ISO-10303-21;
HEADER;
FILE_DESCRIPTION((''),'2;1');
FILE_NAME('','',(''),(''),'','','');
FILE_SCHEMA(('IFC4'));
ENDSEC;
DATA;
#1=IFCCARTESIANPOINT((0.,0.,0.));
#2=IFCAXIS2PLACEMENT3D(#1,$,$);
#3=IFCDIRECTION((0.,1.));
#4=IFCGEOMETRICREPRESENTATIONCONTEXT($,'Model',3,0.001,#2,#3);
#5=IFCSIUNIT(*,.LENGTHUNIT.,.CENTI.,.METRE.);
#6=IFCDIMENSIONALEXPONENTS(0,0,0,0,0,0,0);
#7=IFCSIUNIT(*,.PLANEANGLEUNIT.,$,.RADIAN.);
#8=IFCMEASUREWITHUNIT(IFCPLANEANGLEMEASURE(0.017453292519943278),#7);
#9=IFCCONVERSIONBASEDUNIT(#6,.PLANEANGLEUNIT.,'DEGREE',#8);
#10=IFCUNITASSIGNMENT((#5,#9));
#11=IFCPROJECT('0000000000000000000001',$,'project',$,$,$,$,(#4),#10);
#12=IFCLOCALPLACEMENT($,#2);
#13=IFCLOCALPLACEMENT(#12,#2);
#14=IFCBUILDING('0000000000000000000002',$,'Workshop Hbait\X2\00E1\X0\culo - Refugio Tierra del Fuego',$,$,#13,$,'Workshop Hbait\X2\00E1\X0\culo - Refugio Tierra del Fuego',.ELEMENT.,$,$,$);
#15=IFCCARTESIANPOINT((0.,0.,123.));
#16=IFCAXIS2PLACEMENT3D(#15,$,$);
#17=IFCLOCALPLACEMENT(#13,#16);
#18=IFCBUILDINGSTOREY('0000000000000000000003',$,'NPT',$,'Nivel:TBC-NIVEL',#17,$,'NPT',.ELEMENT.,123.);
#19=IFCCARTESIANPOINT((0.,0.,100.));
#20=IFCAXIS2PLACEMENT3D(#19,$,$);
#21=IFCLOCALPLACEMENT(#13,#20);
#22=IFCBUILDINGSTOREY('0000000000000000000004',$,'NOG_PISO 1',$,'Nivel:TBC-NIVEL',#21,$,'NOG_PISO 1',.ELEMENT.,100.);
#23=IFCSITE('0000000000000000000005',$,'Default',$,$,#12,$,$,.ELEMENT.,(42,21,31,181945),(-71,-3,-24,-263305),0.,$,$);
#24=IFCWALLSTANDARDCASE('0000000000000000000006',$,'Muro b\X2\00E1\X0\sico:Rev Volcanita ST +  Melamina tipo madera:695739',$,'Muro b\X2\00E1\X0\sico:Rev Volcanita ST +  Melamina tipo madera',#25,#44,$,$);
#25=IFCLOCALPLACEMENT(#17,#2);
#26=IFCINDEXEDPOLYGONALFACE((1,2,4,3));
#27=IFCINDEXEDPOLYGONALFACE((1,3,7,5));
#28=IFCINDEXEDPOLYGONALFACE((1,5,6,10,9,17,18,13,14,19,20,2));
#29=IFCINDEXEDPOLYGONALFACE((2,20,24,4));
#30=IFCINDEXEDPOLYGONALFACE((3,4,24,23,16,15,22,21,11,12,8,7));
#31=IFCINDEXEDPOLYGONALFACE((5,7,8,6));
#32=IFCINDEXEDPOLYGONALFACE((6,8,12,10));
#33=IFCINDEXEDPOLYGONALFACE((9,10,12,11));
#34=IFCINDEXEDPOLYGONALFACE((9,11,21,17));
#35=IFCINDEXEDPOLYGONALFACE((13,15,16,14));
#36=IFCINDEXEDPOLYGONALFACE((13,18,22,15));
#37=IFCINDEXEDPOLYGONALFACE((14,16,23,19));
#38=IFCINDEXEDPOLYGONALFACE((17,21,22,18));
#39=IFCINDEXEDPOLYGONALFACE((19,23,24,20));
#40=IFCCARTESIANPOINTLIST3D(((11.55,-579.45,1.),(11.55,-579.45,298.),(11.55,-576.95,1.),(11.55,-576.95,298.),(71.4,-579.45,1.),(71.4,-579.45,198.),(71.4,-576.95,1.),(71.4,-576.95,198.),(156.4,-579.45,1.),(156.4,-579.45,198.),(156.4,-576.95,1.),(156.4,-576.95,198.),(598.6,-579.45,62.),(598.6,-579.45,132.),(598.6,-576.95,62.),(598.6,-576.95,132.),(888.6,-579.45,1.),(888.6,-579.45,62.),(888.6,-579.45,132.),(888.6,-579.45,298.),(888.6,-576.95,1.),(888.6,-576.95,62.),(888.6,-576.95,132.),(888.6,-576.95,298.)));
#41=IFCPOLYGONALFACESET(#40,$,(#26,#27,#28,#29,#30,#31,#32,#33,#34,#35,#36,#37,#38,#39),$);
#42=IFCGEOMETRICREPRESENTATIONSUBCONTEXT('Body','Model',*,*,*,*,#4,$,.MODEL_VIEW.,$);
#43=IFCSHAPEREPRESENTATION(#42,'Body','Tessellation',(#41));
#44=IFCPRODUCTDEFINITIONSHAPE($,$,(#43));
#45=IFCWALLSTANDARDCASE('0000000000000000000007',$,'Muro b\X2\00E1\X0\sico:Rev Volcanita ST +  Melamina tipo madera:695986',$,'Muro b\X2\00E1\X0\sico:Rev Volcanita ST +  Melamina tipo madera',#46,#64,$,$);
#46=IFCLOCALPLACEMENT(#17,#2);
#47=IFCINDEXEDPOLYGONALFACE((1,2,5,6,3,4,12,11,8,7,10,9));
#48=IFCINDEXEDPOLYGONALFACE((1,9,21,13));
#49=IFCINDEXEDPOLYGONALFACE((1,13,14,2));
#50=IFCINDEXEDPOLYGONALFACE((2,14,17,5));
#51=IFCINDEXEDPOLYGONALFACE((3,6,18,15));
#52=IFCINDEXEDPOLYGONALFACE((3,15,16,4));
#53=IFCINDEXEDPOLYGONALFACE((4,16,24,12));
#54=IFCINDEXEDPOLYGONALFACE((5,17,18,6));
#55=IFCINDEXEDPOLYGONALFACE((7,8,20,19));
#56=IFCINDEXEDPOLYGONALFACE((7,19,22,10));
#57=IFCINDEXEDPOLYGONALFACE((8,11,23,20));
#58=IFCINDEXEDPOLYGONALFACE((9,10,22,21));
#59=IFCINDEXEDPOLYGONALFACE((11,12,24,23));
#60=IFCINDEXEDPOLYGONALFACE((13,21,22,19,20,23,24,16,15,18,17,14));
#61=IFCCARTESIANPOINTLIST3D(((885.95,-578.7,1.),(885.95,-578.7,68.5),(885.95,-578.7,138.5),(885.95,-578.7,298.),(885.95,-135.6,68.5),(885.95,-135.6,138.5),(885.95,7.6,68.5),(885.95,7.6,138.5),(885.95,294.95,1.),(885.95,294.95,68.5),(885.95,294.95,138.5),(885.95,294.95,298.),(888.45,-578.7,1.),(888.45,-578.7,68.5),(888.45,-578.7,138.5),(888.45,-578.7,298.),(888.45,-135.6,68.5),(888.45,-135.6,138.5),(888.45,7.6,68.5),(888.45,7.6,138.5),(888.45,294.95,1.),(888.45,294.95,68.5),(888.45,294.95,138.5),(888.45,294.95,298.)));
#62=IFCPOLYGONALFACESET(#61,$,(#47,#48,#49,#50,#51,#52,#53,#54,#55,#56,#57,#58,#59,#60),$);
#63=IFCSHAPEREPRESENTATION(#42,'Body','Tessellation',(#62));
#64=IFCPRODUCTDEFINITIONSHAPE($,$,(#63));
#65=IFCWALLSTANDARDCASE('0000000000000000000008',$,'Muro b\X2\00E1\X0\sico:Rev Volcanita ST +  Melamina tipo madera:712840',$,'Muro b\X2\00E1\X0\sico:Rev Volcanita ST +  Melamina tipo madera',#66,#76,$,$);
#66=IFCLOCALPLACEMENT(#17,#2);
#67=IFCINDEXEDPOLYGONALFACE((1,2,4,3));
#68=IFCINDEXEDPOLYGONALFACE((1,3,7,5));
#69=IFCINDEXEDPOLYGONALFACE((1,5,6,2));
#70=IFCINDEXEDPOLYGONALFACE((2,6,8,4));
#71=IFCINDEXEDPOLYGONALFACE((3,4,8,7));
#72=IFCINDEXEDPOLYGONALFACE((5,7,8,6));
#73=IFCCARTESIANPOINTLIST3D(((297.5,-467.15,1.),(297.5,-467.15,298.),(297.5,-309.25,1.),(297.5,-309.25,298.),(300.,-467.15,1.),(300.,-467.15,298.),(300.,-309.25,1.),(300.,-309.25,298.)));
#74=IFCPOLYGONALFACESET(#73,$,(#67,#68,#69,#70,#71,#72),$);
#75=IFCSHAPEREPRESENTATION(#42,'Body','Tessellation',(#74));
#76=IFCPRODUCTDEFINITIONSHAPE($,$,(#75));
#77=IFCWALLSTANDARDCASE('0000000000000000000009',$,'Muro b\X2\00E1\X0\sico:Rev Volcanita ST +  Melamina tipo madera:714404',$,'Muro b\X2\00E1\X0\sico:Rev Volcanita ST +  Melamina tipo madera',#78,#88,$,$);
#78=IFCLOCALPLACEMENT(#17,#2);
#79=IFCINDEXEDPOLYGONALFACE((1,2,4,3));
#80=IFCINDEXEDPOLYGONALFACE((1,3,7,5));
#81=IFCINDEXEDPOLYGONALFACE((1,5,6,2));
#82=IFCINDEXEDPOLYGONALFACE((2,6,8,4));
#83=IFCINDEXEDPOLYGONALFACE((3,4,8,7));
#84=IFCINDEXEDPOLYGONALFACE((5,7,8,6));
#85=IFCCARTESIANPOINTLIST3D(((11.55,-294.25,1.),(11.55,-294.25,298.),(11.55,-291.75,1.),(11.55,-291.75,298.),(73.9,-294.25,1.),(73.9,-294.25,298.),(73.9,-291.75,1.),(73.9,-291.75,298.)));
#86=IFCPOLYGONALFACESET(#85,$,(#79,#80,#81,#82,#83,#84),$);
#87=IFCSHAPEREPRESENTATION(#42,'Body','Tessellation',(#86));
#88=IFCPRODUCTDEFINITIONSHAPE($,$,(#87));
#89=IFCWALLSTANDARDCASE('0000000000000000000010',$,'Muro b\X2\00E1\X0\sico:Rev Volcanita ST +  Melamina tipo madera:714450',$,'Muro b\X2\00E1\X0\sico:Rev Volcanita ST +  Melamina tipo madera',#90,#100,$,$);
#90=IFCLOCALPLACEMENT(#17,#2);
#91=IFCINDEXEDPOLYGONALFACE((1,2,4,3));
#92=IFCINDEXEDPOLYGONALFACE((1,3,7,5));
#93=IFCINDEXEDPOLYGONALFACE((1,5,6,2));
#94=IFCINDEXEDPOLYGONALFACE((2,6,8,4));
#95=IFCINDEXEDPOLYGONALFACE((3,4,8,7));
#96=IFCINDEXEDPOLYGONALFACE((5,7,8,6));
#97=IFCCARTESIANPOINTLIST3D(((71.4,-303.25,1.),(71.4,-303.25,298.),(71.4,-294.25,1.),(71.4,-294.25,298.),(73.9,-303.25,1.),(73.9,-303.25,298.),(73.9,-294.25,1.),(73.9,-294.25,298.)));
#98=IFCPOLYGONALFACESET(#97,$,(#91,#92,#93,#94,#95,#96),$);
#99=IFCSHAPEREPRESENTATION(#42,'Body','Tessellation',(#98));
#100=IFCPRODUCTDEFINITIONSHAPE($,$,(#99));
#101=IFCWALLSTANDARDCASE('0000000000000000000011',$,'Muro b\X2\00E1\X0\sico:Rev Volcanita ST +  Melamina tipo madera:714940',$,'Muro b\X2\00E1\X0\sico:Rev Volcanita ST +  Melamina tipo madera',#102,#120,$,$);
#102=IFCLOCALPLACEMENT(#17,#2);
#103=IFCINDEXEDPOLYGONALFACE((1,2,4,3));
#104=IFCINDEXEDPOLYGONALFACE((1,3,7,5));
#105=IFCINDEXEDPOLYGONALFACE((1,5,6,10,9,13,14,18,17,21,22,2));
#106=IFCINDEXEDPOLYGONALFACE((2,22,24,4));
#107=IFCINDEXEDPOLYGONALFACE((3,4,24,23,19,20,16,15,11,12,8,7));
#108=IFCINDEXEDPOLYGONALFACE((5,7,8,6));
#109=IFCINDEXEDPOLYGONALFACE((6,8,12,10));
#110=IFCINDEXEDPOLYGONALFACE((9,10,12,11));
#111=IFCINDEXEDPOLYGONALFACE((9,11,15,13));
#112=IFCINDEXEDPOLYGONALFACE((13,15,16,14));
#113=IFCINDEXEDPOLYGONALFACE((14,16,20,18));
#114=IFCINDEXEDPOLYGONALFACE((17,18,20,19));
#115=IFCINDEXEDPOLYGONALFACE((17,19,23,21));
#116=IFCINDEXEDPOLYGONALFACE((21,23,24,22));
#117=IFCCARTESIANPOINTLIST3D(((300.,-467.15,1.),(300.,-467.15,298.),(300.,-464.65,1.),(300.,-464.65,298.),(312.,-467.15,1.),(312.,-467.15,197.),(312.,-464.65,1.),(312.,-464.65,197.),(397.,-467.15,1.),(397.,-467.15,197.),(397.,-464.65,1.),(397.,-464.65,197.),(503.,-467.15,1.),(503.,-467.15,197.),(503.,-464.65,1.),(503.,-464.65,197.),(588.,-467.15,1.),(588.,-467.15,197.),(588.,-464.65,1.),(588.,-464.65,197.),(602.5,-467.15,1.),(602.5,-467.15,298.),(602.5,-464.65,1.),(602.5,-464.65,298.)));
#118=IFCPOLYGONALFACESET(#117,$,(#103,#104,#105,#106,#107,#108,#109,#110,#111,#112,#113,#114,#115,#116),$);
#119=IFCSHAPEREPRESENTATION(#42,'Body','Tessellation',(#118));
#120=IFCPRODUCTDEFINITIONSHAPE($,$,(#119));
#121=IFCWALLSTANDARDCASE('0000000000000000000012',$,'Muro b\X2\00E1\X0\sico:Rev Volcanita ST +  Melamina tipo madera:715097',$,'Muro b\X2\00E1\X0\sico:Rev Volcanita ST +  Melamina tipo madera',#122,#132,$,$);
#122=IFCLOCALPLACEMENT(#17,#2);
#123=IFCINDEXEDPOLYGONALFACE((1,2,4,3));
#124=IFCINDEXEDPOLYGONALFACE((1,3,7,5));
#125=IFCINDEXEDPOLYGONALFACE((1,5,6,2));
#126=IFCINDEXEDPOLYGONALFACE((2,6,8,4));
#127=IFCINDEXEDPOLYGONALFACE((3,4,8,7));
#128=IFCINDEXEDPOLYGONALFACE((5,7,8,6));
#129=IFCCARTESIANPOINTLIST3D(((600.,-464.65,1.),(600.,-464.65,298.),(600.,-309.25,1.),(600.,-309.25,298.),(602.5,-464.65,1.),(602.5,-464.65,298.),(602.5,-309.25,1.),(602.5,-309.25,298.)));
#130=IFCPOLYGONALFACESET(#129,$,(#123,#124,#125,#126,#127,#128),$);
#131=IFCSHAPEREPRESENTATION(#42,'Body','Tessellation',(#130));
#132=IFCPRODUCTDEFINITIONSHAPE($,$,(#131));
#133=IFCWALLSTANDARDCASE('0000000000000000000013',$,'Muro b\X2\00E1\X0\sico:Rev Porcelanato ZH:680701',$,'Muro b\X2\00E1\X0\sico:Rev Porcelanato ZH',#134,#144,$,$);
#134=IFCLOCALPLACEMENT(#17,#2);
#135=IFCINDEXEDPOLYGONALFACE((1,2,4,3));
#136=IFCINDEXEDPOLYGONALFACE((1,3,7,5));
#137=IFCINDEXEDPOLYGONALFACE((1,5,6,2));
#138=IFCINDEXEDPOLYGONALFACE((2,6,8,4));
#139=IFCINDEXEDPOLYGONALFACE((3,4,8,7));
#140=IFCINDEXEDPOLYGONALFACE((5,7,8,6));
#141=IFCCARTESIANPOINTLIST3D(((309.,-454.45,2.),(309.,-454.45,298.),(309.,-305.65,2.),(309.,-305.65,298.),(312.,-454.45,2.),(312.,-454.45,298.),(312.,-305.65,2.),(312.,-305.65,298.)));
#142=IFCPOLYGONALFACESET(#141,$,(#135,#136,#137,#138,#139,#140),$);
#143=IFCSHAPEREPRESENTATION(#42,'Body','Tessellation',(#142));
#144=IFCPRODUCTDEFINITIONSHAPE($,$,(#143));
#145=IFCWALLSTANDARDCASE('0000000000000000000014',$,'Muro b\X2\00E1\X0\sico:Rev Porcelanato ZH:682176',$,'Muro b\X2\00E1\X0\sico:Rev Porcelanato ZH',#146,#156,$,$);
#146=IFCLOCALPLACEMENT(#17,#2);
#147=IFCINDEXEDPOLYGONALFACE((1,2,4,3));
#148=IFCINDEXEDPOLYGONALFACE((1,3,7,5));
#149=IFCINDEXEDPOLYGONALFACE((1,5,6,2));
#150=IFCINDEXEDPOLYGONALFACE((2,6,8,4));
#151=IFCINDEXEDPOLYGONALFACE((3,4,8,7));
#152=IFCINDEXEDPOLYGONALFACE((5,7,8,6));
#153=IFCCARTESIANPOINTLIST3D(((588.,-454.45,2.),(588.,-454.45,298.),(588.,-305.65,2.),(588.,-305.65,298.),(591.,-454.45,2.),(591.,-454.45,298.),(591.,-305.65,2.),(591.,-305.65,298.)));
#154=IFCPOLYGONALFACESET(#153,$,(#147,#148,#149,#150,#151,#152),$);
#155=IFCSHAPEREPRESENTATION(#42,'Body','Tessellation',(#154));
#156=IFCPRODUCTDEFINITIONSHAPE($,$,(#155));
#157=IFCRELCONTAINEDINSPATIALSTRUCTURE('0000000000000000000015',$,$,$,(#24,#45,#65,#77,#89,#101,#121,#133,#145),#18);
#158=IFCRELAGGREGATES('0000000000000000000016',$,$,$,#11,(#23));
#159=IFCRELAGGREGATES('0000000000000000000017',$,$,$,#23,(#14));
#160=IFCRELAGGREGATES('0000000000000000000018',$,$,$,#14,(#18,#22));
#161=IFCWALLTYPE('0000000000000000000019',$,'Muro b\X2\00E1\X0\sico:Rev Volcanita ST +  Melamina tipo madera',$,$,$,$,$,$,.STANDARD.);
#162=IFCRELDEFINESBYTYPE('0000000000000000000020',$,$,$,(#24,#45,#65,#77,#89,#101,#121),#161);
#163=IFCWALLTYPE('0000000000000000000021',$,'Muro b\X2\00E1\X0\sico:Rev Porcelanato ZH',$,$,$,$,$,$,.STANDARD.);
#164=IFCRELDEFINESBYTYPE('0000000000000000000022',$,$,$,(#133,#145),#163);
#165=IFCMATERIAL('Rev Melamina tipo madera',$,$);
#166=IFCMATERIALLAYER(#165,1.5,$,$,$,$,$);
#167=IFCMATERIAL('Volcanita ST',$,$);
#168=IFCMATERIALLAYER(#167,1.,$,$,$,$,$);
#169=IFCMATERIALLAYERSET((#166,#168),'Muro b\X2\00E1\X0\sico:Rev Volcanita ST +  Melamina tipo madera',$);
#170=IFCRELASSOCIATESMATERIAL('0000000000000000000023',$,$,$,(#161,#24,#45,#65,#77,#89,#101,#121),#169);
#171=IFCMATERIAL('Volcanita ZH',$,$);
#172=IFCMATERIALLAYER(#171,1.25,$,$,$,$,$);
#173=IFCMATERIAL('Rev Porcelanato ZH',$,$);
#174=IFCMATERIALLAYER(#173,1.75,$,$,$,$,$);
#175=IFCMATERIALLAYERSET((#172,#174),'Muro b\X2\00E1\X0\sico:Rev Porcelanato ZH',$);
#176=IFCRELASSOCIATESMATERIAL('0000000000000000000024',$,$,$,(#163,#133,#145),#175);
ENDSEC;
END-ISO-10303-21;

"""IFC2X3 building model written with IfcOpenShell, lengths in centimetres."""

from ifc_helpers import new_model, entity, si_unit, converted_unit, direction, frame, frame_2d, origin, place, context, subcontext, project, spatial, rectangle, extrude, material, layer, layer_set, layer_usage, type_object, element, save


model = new_model("IFC2X3")

# Units and contexts
model_context = context("Model", 3, precision=0.001, world=origin(), true_north=direction((0.0, 1.0)))
body_context = subcontext(model_context, "Body", "Model", "MODEL_VIEW")
ifc_project = project(units=[si_unit("LENGTHUNIT", "METRE", prefix="CENTI"), converted_unit("PLANEANGLEUNIT", "DEGREE", entity("IfcPlaneAngleMeasure", 0.017453292519943278), si_unit("PLANEANGLEUNIT", "RADIAN"), dimensions=[0, 0, 0, 0, 0, 0, 0])], contexts=[model_context])

# Site, building, storey
site_placement = place(None, origin())
site = spatial("IfcSite", under=ifc_project, at=site_placement, Name="Default", CompositionType="ELEMENT", RefLatitude=(42, 21, 31, 181945), RefLongitude=(-71, -3, -24, -263305), RefElevation=0.0)
building_placement = place(site_placement, origin())
building = spatial("IfcBuilding", under=site, at=building_placement, Name="Workshop Hbaitáculo - Refugio Tierra del Fuego", LongName="Workshop Hbaitáculo - Refugio Tierra del Fuego", CompositionType="ELEMENT")
storey_1_placement = place(building_placement, frame((0.0, 0.0, 123.0)))
storey_1 = spatial("IfcBuildingStorey", under=building, at=storey_1_placement, Name="NPT", ObjectType="Nivel:TBC-NIVEL", LongName="NPT", CompositionType="ELEMENT", Elevation=123.0)

# Shared definitions
storey_2_placement = place(building_placement, frame((0.0, 0.0, 100.0)))
storey_2 = spatial("IfcBuildingStorey", under=building, at=storey_2_placement, Name="NOG_PISO 1", ObjectType="Nivel:TBC-NIVEL", LongName="NOG_PISO 1", CompositionType="ELEMENT", Elevation=100.0)

# Shared definitions
ifc_material_1 = material(Name="Rev Melamina tipo madera")
ifc_layer_1 = layer(ifc_material_1, 1.5)
ifc_material_2 = material(Name="Volcanita ST")
ifc_layer_2 = layer(ifc_material_2, 1.0)
ifc_layer_set_1 = layer_set([ifc_layer_1, ifc_layer_2], Name="Muro básico:Rev Volcanita ST +  Melamina tipo madera")
wall_type_1 = type_object("IfcWallType", Name="Muro básico:Rev Volcanita ST +  Melamina tipo madera", PredefinedType="STANDARD", material=ifc_layer_set_1)

# Walls, openings
ifc_layer_usage_1 = layer_usage(ifc_layer_set_1, "AXIS2", "NEGATIVE", 1.25)
wall_1_placement = place(storey_1_placement, frame((11.55, -578.2, 1.0)))
wall_1 = element("IfcWallStandardCase", 1, at=wall_1_placement, inside=storey_1, type_object=wall_type_1, material=ifc_layer_usage_1, Name="Muro básico:Rev Volcanita ST +  Melamina tipo madera:695739", ObjectType="Muro básico:Rev Volcanita ST +  Melamina tipo madera", context=body_context, shape_type="SweptSolid", body=[
    extrude(rectangle(XDim=877.05, YDim=2.5, at=frame_2d((438.53, 0.0), x_axis=(-1.0, 0.0))), origin(), (0.0, 0.0, 1.0), 297.0),
])
opening_1_placement = place(wall_1_placement, origin())
element("IfcOpeningElement", 2, at=opening_1_placement, cuts=wall_1, ObjectType="Opening", context=body_context, shape_type="SweptSolid", body=[
    extrude(rectangle(XDim=70.0, YDim=290.0, at=frame_2d((0.0, 0.0), x_axis=(1.0, 0.0))), frame((732.05, 1.25, 96.0), z_axis=(0.0, -1.0, 0.0), x_axis=(0.0, 0.0, 1.0)), (0.0, 0.0, 1.0), 2.5),
])
opening_2_placement = place(wall_1_placement, origin())
element("IfcOpeningElement", 3, at=opening_2_placement, cuts=wall_1, ObjectType="Opening", context=body_context, shape_type="SweptSolid", body=[
    extrude(rectangle(XDim=197.0, YDim=85.0, at=frame_2d((0.0, 0.0), x_axis=(0.0, 1.0))), frame((102.35, 1.25, 98.5), z_axis=(0.0, -1.0, 0.0), x_axis=(1.0, 0.0, 0.0)), (0.0, 0.0, 1.0), 2.5),
])
ifc_layer_usage_2 = layer_usage(ifc_layer_set_1, "AXIS2", "NEGATIVE", 1.25)
wall_2_placement = place(storey_1_placement, frame((887.2, -578.7, 1.0), z_axis=(0.0, 0.0, 1.0), x_axis=(0.0, 1.0, 0.0)))
wall_2 = element("IfcWallStandardCase", 4, at=wall_2_placement, inside=storey_1, type_object=wall_type_1, material=ifc_layer_usage_2, Name="Muro básico:Rev Volcanita ST +  Melamina tipo madera:695986", ObjectType="Muro básico:Rev Volcanita ST +  Melamina tipo madera", context=body_context, shape_type="SweptSolid", body=[
    extrude(rectangle(XDim=873.65, YDim=2.5, at=frame_2d((436.82, 0.0), x_axis=(-1.0, 0.0))), origin(), (0.0, 0.0, 1.0), 297.0),
])
opening_3_placement = place(wall_2_placement, origin())
element("IfcOpeningElement", 5, at=opening_3_placement, cuts=wall_2, ObjectType="Opening", context=body_context, shape_type="SweptSolid", body=[
    extrude(rectangle(XDim=70.0, YDim=288.6, at=frame_2d((0.0, 0.0), x_axis=(0.0, 1.0))), frame((730.6, 1.25, 102.5), z_axis=(0.0, -1.0, 0.0), x_axis=(-1.0, 0.0, 0.0)), (0.0, 0.0, 1.0), 2.5),
])
opening_4_placement = place(wall_2_placement, origin())
element("IfcOpeningElement", 6, at=opening_4_placement, cuts=wall_2, ObjectType="Opening", context=body_context, shape_type="SweptSolid", body=[
    extrude(rectangle(XDim=70.0, YDim=443.1, at=frame_2d((0.0, 0.0), x_axis=(0.0, 1.0))), frame((221.55, 1.25, 102.5), z_axis=(0.0, -1.0, 0.0), x_axis=(1.0, 0.0, 0.0)), (0.0, 0.0, 1.0), 2.5),
])

# Walls
ifc_layer_usage_3 = layer_usage(ifc_layer_set_1, "AXIS2", "POSITIVE", -1.25)
wall_3_placement = place(storey_1_placement, frame((298.75, -309.25, 1.0), z_axis=(0.0, 0.0, 1.0), x_axis=(0.0, -1.0, 0.0)))
element("IfcWallStandardCase", 7, at=wall_3_placement, inside=storey_1, type_object=wall_type_1, material=ifc_layer_usage_3, Name="Muro básico:Rev Volcanita ST +  Melamina tipo madera:712840", ObjectType="Muro básico:Rev Volcanita ST +  Melamina tipo madera", context=body_context, shape_type="SweptSolid", body=[
    extrude(rectangle(XDim=157.9, YDim=2.5, at=frame_2d((78.95, 0.0), x_axis=(-1.0, 0.0))), origin(), (0.0, 0.0, 1.0), 297.0),
])
ifc_layer_usage_4 = layer_usage(ifc_layer_set_1, "AXIS2", "NEGATIVE", 1.25)
wall_4_placement = place(storey_1_placement, frame((11.55, -293.0, 1.0)))
element("IfcWallStandardCase", 8, at=wall_4_placement, inside=storey_1, type_object=wall_type_1, material=ifc_layer_usage_4, Name="Muro básico:Rev Volcanita ST +  Melamina tipo madera:714404", ObjectType="Muro básico:Rev Volcanita ST +  Melamina tipo madera", context=body_context, shape_type="SweptSolid", body=[
    extrude(rectangle(XDim=62.35, YDim=2.5, at=frame_2d((31.17, 0.0), x_axis=(-1.0, 0.0))), origin(), (0.0, 0.0, 1.0), 297.0),
])
ifc_layer_usage_5 = layer_usage(ifc_layer_set_1, "AXIS2", "POSITIVE", -1.25)
wall_5_placement = place(storey_1_placement, frame((72.65, -303.25, 1.0), z_axis=(0.0, 0.0, 1.0), x_axis=(0.0, 1.0, 0.0)))
element("IfcWallStandardCase", 9, at=wall_5_placement, inside=storey_1, type_object=wall_type_1, material=ifc_layer_usage_5, Name="Muro básico:Rev Volcanita ST +  Melamina tipo madera:714450", ObjectType="Muro básico:Rev Volcanita ST +  Melamina tipo madera", context=body_context, shape_type="SweptSolid", body=[
    extrude(rectangle(XDim=9.0, YDim=2.5, at=frame_2d((4.5, 0.0), x_axis=(-1.0, 0.0))), origin(), (0.0, 0.0, 1.0), 297.0),
])

# Wall, openings
ifc_layer_usage_6 = layer_usage(ifc_layer_set_1, "AXIS2", "POSITIVE", -1.25)
wall_6_placement = place(storey_1_placement, frame((300.0, -465.9, 1.0)))
wall_6 = element("IfcWallStandardCase", 10, at=wall_6_placement, inside=storey_1, type_object=wall_type_1, material=ifc_layer_usage_6, Name="Muro básico:Rev Volcanita ST +  Melamina tipo madera:714940", ObjectType="Muro básico:Rev Volcanita ST +  Melamina tipo madera", context=body_context, shape_type="SweptSolid", body=[
    extrude(rectangle(XDim=302.5, YDim=2.5, at=frame_2d((151.25, 0.0), x_axis=(-1.0, 0.0))), origin(), (0.0, 0.0, 1.0), 297.0),
])
opening_5_placement = place(wall_6_placement, origin())
element("IfcOpeningElement", 11, at=opening_5_placement, cuts=wall_6, ObjectType="Opening", context=body_context, shape_type="SweptSolid", body=[
    extrude(rectangle(XDim=196.0, YDim=85.0, at=frame_2d((0.0, 0.0), x_axis=(1.0, 0.0))), frame((245.5, 1.25, 98.0), z_axis=(0.0, -1.0, 0.0), x_axis=(0.0, 0.0, 1.0)), (0.0, 0.0, 1.0), 2.5),
])
opening_6_placement = place(wall_6_placement, origin())
element("IfcOpeningElement", 12, at=opening_6_placement, cuts=wall_6, ObjectType="Opening", context=body_context, shape_type="SweptSolid", body=[
    extrude(rectangle(XDim=196.0, YDim=85.0, at=frame_2d((0.0, 0.0), x_axis=(1.0, 0.0))), frame((54.5, 1.25, 98.0), z_axis=(0.0, -1.0, 0.0), x_axis=(0.0, 0.0, 1.0)), (0.0, 0.0, 1.0), 2.5),
])

# Walls
ifc_layer_usage_7 = layer_usage(ifc_layer_set_1, "AXIS2", "POSITIVE", -1.25)
wall_7_placement = place(storey_1_placement, frame((601.25, -464.65, 1.0), z_axis=(0.0, 0.0, 1.0), x_axis=(0.0, 1.0, 0.0)))
element("IfcWallStandardCase", 13, at=wall_7_placement, inside=storey_1, type_object=wall_type_1, material=ifc_layer_usage_7, Name="Muro básico:Rev Volcanita ST +  Melamina tipo madera:715097", ObjectType="Muro básico:Rev Volcanita ST +  Melamina tipo madera", context=body_context, shape_type="SweptSolid", body=[
    extrude(rectangle(XDim=155.4, YDim=2.5, at=frame_2d((77.7, 0.0), x_axis=(-1.0, 0.0))), origin(), (0.0, 0.0, 1.0), 297.0),
])
ifc_material_3 = material(Name="Volcanita ZH")
ifc_layer_3 = layer(ifc_material_3, 1.25)
ifc_material_4 = material(Name="Rev Porcelanato ZH")
ifc_layer_4 = layer(ifc_material_4, 1.75)
ifc_layer_set_2 = layer_set([ifc_layer_3, ifc_layer_4], Name="Muro básico:Rev Porcelanato ZH")
ifc_layer_usage_8 = layer_usage(ifc_layer_set_2, "AXIS2", "NEGATIVE", 1.5)
wall_type_2 = type_object("IfcWallType", Name="Muro básico:Rev Porcelanato ZH", PredefinedType="STANDARD", material=ifc_layer_set_2)
wall_8_placement = place(storey_1_placement, frame((310.5, -454.45, 2.0), z_axis=(0.0, 0.0, 1.0), x_axis=(0.0, 1.0, 0.0)))
element("IfcWallStandardCase", 14, at=wall_8_placement, inside=storey_1, type_object=wall_type_2, material=ifc_layer_usage_8, Name="Muro básico:Rev Porcelanato ZH:680701", ObjectType="Muro básico:Rev Porcelanato ZH", context=body_context, shape_type="SweptSolid", body=[
    extrude(rectangle(XDim=148.8, YDim=3.0, at=frame_2d((74.4, 0.0), x_axis=(-1.0, 0.0))), origin(), (0.0, 0.0, 1.0), 296.0),
])
ifc_layer_usage_9 = layer_usage(ifc_layer_set_2, "AXIS2", "POSITIVE", -1.5)
wall_9_placement = place(storey_1_placement, frame((589.5, -454.45, 2.0), z_axis=(0.0, 0.0, 1.0), x_axis=(0.0, 1.0, 0.0)))
element("IfcWallStandardCase", 15, at=wall_9_placement, inside=storey_1, type_object=wall_type_2, material=ifc_layer_usage_9, Name="Muro básico:Rev Porcelanato ZH:682176", ObjectType="Muro básico:Rev Porcelanato ZH", context=body_context, shape_type="SweptSolid", body=[
    extrude(rectangle(XDim=148.8, YDim=3.0, at=frame_2d((74.4, 0.0), x_axis=(-1.0, 0.0))), origin(), (0.0, 0.0, 1.0), 296.0),
])

save(model, "model.ifc")
